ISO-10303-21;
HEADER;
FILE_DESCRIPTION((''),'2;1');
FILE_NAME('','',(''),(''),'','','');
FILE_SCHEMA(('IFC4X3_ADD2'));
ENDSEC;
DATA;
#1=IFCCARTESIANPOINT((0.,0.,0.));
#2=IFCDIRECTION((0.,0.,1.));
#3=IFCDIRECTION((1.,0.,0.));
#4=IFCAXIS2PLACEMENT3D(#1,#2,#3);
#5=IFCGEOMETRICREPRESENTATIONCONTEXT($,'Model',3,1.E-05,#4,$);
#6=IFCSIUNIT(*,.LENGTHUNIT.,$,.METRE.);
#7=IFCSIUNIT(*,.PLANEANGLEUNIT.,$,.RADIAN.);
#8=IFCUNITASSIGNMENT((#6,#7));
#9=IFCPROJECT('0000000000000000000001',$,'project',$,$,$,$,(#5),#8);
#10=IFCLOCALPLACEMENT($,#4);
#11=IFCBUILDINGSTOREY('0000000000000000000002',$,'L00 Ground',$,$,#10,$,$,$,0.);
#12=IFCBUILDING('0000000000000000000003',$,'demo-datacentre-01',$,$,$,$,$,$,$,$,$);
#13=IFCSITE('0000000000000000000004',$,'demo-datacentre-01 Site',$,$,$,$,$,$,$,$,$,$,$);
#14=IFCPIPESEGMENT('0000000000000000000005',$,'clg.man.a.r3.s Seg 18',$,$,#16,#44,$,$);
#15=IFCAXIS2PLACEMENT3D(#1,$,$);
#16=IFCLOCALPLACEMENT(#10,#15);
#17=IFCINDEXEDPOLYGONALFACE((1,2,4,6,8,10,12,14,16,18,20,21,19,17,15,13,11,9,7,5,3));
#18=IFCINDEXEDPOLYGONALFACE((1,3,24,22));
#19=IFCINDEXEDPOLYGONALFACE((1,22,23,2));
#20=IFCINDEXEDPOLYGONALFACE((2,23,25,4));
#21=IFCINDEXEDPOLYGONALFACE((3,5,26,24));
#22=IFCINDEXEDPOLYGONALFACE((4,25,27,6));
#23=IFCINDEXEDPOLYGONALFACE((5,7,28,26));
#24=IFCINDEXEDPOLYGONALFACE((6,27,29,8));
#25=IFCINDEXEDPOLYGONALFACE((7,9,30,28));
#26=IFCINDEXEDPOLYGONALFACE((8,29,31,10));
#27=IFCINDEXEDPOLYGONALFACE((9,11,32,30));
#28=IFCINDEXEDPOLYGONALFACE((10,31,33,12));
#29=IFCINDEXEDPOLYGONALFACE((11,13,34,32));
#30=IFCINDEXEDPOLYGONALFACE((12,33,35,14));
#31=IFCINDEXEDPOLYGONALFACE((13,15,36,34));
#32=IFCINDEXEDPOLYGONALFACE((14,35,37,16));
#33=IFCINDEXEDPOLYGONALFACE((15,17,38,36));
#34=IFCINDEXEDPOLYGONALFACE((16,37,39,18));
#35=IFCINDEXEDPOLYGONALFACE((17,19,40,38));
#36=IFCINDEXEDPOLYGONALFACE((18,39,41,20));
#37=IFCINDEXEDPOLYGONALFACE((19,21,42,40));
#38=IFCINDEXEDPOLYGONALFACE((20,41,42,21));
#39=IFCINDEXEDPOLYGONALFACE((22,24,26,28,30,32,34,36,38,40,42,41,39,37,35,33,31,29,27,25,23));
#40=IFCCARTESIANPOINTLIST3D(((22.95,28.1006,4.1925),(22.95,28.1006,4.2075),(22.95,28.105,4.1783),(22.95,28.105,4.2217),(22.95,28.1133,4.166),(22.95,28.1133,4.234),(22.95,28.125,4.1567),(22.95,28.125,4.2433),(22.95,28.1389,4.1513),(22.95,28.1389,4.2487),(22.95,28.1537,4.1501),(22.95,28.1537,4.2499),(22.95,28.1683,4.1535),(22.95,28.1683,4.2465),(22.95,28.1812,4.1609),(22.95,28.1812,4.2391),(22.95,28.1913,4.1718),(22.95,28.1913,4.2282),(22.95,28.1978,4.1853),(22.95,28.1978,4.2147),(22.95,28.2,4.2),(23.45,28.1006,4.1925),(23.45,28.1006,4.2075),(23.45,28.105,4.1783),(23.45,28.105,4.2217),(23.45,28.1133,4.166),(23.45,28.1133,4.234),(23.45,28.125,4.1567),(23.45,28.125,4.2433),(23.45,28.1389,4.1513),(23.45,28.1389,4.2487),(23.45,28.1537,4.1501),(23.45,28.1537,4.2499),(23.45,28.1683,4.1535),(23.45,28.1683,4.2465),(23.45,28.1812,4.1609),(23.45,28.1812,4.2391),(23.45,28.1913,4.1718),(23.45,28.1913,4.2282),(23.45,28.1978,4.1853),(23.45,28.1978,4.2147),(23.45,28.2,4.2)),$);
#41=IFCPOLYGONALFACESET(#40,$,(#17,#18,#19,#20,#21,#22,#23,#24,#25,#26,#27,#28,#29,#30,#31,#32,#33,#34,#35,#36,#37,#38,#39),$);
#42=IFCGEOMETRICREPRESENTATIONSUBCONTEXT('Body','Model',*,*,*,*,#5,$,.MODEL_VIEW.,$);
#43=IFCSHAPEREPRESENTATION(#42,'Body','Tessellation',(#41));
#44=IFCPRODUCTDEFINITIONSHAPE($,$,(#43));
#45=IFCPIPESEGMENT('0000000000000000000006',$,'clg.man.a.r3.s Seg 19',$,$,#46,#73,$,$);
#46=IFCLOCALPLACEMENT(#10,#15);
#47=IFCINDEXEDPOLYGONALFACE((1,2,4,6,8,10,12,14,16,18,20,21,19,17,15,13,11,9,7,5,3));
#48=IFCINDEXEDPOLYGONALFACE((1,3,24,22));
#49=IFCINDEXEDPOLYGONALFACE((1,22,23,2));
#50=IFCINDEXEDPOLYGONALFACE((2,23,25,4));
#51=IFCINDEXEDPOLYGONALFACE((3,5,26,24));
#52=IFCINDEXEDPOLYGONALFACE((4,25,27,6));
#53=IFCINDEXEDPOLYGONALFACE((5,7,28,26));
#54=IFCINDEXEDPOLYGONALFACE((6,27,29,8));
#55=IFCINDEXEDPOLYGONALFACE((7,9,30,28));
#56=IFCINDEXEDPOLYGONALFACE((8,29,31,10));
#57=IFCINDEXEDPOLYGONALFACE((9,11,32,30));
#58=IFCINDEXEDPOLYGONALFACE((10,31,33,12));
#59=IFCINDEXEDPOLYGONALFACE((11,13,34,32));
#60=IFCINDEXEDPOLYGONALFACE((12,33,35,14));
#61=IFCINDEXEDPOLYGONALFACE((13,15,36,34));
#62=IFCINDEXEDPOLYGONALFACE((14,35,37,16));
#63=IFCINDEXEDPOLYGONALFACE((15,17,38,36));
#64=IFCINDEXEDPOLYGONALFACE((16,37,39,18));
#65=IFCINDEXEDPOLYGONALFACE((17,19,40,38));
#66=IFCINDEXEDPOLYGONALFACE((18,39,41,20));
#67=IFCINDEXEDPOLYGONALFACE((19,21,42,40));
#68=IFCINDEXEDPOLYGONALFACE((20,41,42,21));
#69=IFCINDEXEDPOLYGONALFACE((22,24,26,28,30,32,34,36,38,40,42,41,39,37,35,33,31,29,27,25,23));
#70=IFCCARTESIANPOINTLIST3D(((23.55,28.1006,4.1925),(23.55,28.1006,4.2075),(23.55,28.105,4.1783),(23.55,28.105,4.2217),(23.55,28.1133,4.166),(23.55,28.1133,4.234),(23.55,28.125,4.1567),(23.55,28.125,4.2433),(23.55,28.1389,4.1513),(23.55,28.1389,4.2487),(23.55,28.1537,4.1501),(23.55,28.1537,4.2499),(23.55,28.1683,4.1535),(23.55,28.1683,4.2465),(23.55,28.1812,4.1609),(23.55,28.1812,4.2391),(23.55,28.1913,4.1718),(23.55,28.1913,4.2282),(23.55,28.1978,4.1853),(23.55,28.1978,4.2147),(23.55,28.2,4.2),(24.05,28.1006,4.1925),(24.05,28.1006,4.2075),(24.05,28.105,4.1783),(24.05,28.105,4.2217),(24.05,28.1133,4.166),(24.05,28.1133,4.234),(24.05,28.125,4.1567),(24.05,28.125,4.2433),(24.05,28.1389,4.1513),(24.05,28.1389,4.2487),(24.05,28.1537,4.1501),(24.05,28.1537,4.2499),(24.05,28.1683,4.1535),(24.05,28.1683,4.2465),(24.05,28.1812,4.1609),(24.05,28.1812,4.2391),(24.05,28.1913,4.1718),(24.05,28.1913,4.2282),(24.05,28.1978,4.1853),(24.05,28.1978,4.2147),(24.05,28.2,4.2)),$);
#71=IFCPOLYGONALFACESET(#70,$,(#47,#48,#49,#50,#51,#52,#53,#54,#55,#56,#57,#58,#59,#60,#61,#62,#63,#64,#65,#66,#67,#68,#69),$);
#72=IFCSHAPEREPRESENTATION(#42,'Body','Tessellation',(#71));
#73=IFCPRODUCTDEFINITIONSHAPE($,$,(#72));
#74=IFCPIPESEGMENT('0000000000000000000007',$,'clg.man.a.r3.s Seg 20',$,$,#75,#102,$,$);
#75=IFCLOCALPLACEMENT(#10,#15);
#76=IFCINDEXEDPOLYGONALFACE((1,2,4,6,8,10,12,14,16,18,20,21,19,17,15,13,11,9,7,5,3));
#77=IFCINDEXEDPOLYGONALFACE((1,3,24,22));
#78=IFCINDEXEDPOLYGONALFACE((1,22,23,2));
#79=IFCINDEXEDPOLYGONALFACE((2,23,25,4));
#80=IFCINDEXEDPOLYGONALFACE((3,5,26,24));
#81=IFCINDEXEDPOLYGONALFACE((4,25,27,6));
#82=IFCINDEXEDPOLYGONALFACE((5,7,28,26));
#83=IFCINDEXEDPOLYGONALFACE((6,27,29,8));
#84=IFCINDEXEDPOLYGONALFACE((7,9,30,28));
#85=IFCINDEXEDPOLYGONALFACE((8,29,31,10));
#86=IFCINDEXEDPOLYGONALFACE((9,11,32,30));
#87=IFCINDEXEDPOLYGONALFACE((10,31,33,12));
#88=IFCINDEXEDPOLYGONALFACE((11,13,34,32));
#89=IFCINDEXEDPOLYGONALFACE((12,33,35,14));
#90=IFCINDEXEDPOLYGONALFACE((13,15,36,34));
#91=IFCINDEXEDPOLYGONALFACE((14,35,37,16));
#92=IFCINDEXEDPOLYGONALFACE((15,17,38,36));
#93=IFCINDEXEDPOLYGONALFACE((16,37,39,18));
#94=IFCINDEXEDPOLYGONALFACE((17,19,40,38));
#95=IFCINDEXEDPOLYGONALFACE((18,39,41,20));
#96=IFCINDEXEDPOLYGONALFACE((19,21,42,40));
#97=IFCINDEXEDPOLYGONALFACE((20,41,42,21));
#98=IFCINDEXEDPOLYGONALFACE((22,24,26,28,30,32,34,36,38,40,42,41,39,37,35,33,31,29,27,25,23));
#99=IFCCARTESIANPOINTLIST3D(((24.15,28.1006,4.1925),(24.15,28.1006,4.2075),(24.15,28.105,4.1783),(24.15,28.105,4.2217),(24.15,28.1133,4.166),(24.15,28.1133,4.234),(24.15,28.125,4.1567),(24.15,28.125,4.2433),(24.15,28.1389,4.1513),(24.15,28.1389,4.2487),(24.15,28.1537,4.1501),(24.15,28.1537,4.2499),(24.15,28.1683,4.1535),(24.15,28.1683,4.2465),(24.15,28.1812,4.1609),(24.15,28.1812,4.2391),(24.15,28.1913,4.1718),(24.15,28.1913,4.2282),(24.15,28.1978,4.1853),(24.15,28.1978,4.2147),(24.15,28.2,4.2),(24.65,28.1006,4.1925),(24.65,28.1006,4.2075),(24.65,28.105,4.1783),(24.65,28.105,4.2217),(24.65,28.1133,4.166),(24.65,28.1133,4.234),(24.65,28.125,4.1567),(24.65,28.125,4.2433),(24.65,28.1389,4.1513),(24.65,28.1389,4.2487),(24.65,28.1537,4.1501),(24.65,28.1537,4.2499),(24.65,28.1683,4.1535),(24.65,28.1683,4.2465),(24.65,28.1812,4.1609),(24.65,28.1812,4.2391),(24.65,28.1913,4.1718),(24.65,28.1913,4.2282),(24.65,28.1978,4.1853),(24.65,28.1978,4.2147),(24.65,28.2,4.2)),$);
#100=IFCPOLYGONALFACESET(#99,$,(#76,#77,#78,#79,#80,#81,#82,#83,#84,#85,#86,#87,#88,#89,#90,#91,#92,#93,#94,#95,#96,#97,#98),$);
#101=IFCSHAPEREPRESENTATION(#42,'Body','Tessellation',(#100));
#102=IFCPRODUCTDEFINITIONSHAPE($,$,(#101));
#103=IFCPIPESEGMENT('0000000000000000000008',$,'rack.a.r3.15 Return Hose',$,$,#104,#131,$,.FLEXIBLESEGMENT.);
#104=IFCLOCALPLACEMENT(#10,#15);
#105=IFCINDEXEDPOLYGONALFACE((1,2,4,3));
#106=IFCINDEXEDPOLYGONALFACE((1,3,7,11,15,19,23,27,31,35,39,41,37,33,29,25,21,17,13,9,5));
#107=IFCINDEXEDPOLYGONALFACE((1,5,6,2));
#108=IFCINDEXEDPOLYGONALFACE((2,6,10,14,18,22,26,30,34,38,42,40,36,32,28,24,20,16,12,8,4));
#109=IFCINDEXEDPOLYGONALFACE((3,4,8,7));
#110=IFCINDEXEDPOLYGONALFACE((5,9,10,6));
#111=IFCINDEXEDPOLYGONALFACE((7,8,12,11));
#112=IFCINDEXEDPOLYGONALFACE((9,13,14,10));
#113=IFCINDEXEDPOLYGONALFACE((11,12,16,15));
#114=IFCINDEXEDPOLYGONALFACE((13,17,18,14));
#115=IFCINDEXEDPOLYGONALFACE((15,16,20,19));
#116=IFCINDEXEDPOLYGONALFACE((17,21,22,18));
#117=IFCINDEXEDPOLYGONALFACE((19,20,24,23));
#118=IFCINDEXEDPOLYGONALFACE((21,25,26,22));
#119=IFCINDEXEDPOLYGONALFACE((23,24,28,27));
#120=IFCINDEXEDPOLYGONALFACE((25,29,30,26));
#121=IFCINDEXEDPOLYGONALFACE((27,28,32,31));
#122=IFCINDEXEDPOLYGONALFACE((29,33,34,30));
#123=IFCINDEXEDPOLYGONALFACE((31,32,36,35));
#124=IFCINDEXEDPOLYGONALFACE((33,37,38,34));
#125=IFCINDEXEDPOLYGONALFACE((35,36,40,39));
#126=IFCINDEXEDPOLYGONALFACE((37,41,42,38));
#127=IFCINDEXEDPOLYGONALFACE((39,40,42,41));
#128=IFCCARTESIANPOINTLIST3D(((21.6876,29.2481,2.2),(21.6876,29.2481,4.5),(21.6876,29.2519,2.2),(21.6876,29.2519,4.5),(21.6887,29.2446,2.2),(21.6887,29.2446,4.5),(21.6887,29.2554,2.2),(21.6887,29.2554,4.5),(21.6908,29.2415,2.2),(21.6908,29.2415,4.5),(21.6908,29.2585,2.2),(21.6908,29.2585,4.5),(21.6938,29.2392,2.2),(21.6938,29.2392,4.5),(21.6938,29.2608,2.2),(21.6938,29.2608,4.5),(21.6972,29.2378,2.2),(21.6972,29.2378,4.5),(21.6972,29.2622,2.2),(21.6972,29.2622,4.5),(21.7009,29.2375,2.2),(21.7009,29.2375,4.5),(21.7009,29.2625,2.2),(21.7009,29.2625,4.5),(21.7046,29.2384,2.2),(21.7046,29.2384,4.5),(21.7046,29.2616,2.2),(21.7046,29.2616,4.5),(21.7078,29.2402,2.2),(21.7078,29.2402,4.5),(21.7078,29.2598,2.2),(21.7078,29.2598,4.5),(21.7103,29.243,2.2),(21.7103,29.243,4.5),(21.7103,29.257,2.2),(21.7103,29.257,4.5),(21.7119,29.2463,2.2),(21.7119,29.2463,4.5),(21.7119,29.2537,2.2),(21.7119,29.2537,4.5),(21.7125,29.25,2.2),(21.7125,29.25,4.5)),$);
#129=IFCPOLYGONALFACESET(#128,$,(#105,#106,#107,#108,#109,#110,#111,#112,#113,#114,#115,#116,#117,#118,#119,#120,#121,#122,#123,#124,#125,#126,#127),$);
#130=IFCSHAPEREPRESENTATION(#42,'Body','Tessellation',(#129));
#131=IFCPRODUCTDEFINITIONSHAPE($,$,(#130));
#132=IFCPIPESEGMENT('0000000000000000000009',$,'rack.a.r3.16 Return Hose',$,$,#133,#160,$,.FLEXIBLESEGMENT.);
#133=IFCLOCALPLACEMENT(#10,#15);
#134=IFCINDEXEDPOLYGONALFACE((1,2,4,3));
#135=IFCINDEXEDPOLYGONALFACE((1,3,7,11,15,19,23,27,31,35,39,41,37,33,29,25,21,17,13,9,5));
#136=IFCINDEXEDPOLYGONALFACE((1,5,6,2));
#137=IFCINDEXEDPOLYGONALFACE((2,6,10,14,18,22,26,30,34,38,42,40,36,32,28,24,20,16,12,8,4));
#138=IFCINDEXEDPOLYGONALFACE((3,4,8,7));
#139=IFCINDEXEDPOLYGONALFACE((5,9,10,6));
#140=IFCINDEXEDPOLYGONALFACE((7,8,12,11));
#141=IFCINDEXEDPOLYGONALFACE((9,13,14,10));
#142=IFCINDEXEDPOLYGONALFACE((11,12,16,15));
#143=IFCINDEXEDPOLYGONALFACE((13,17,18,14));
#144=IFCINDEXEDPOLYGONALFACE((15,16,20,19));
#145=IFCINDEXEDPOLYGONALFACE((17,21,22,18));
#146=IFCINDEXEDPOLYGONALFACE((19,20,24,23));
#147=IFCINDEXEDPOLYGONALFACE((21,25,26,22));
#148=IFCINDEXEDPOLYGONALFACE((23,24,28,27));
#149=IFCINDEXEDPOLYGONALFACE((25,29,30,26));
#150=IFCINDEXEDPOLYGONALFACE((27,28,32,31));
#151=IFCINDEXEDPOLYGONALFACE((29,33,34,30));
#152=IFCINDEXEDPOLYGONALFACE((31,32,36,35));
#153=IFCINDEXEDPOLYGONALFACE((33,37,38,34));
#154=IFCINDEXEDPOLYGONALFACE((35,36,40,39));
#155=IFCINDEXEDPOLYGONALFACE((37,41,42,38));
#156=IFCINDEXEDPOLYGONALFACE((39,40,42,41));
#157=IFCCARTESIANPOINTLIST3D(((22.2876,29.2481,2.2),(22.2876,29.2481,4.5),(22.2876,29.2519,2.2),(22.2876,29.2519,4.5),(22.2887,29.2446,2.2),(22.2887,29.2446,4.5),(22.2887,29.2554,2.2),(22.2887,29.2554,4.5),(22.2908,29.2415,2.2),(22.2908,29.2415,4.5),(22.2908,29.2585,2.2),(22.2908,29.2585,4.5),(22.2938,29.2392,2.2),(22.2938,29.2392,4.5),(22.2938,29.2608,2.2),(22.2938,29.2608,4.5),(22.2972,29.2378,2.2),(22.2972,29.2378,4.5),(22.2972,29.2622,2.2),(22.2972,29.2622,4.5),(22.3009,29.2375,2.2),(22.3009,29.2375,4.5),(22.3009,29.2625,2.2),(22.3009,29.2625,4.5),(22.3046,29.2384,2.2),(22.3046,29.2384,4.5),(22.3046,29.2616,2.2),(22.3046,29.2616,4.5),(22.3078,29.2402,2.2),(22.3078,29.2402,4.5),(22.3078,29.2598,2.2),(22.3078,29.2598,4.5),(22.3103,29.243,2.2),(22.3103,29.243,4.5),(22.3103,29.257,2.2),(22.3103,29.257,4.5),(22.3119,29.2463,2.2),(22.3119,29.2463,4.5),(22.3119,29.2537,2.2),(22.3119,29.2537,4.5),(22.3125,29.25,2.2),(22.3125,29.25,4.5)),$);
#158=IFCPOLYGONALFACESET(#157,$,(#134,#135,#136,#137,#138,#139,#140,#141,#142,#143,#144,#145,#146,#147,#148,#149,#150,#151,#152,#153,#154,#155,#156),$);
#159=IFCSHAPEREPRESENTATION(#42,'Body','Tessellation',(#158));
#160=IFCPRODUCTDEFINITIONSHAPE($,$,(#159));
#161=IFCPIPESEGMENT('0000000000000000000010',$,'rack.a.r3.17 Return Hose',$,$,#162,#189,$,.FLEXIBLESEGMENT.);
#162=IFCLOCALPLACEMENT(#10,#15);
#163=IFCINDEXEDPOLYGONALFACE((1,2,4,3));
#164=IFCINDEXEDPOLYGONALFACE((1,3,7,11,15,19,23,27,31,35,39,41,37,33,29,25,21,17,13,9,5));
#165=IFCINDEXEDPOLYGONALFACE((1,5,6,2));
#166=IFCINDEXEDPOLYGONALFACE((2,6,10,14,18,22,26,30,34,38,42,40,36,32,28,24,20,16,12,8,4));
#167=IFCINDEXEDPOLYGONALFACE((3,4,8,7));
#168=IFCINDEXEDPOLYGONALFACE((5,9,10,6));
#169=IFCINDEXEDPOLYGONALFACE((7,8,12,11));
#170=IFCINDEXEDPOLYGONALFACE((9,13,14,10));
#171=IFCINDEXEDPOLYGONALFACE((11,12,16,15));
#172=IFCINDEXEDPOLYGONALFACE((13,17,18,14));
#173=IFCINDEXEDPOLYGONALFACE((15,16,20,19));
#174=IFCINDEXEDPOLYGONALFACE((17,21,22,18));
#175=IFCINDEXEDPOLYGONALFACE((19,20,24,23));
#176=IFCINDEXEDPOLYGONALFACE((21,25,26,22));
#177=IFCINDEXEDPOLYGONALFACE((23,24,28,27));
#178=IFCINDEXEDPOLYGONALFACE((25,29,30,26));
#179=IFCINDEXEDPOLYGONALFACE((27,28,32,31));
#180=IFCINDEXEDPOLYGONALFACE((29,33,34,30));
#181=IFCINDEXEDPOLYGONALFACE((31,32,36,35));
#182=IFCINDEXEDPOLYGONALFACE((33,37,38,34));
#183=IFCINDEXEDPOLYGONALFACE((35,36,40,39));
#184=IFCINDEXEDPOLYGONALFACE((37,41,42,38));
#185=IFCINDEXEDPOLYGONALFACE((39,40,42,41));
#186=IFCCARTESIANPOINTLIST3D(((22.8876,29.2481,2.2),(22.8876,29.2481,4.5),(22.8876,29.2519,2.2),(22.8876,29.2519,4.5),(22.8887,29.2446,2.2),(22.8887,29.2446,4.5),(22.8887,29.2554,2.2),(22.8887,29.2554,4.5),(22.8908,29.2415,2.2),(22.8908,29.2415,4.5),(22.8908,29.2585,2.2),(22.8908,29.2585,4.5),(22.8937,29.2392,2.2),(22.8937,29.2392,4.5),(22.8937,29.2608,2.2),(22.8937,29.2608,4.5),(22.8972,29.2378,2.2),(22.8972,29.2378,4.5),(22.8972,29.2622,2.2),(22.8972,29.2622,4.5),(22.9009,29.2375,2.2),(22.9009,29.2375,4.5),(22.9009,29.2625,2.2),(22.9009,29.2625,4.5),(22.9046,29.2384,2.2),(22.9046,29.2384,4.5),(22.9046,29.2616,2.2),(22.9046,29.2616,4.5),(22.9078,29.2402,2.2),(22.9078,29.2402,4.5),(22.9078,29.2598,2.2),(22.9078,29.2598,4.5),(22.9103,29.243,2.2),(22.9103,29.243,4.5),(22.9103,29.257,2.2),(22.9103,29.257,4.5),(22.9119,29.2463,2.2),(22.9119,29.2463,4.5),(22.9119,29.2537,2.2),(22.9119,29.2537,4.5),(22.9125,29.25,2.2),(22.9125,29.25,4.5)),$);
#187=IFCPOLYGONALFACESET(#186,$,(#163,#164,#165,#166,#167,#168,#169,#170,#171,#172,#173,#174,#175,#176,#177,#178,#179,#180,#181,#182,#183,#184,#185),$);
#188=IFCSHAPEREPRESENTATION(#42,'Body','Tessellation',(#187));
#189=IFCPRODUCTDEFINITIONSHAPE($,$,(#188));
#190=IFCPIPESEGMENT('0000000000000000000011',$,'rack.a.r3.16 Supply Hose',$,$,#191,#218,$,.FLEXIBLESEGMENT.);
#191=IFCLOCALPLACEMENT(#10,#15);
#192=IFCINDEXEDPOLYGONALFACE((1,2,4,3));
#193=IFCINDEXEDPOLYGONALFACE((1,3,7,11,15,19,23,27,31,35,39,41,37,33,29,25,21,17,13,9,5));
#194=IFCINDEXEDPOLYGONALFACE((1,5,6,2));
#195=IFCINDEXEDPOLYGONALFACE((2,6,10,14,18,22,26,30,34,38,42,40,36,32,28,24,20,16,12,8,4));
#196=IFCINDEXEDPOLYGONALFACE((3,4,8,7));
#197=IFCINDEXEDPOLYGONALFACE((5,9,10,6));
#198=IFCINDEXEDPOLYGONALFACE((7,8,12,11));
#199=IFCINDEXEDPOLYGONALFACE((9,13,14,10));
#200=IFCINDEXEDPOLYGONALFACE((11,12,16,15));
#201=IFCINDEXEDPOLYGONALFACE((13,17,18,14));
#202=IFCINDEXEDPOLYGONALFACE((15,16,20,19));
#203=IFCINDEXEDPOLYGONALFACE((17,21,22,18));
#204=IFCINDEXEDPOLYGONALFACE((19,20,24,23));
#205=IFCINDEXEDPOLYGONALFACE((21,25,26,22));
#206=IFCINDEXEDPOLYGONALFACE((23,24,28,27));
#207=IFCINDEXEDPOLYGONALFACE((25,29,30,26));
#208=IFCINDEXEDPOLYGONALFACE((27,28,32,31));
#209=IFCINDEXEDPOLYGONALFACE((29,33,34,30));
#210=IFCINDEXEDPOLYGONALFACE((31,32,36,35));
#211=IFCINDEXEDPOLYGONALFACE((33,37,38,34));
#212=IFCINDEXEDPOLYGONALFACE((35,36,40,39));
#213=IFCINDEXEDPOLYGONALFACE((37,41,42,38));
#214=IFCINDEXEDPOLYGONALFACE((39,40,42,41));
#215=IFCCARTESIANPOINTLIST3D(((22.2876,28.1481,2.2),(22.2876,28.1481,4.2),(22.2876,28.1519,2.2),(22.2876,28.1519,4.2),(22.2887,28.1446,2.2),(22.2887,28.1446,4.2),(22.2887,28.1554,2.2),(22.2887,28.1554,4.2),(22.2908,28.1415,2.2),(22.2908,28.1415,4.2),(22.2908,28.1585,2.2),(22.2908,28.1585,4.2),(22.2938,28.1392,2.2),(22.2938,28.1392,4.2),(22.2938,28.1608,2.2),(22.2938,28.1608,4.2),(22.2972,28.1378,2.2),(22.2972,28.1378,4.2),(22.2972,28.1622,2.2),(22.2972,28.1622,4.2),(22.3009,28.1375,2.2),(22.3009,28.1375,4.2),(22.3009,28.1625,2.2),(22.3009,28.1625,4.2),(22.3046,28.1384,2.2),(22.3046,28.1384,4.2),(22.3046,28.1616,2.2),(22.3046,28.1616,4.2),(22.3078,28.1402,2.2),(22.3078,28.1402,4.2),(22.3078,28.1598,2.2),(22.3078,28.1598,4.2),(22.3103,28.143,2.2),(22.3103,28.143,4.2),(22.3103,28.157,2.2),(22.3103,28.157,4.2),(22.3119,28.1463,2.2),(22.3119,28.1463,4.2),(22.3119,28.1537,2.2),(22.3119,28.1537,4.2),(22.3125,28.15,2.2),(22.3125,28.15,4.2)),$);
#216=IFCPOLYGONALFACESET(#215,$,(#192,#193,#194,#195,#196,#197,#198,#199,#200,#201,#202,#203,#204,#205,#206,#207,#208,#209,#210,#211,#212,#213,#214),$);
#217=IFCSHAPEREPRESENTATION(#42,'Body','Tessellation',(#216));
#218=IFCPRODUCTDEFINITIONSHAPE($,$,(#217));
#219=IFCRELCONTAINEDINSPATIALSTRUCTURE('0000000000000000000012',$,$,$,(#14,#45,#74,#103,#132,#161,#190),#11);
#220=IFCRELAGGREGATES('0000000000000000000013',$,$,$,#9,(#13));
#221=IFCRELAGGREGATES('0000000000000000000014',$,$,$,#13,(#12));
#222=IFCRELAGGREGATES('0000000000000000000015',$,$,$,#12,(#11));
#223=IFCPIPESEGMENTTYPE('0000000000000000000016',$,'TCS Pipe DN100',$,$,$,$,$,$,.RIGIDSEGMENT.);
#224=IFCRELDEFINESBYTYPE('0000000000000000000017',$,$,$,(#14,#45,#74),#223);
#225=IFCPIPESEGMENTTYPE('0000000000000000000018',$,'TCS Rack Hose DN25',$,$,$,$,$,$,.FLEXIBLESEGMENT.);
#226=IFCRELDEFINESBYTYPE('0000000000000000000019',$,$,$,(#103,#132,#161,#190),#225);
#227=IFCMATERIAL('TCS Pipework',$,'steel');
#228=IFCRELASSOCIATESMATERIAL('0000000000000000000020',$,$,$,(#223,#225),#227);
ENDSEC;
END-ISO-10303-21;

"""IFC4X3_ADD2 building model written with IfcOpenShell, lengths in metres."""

from ifc_helpers import new_model, si_unit, frame, origin_with_axes, place, context, subcontext, project, spatial, circle, extrude, material, type_object, element, save


model = new_model("IFC4X3_ADD2")

# Units and contexts
model_context = context("Model", 3, precision=1e-05, world=origin_with_axes())
body_context = subcontext(model_context, "Body", "Model", "MODEL_VIEW")
ifc_project = project(units=[si_unit("LENGTHUNIT", "METRE"), si_unit("PLANEANGLEUNIT", "RADIAN")], contexts=[model_context])

# Site, building, storey
site = spatial("IfcSite", under=ifc_project, Name="demo-datacentre-01 Site")
building = spatial("IfcBuilding", under=site, Name="demo-datacentre-01")
storey_placement = place(None, origin_with_axes())
storey = spatial("IfcBuildingStorey", under=building, at=storey_placement, Name="L00 Ground", Elevation=0.0)

# Shared definitions
ifc_material = material(Name="TCS Pipework", Category="steel")

# Pipe segments
pipe_segment_type_1 = type_object("IfcPipeSegmentType", Name="TCS Pipe DN100", PredefinedType="RIGIDSEGMENT", material=ifc_material)
for number, where, z_axis, x_axis, name in (
    (1, (22.95, 28.15, 4.2), (1.0, 0.0, 0.0), (0.0, 1.0, 0.0), "clg.man.a.r3.s Seg 18"),
    (2, (23.55, 28.15, 4.2), (1.0, 0.0, 0.0), (0.0, 1.0, 0.0), "clg.man.a.r3.s Seg 19"),
    (3, (24.15, 28.15, 4.2), (1.0, 0.0, 0.0), (0.0, 1.0, 0.0), "clg.man.a.r3.s Seg 20"),
):
    element("IfcPipeSegment", number, at=place(storey_placement, frame(where, z_axis=z_axis, x_axis=x_axis)), inside=storey, type_object=pipe_segment_type_1, Name=name, context=body_context, shape_type="SweptSolid", body=[
        extrude(circle(Radius=0.05), origin_with_axes(), (0.0, 0.0, 1.0), 0.5),
    ])
pipe_segment_type_2 = type_object("IfcPipeSegmentType", Name="TCS Rack Hose DN25", PredefinedType="FLEXIBLESEGMENT", material=ifc_material)
for number, where, z_axis, x_axis, name in (
    (4, (21.7, 29.25, 4.5), (0.0, 0.0, -1.0), (1.0, 0.0, 0.0), "rack.a.r3.15 Return Hose"),
    (5, (22.3, 29.25, 4.5), (0.0, 0.0, -1.0), (1.0, 0.0, 0.0), "rack.a.r3.16 Return Hose"),
    (6, (22.9, 29.25, 4.5), (0.0, 0.0, -1.0), (1.0, 0.0, 0.0), "rack.a.r3.17 Return Hose"),
):
    element("IfcPipeSegment", number, at=place(storey_placement, frame(where, z_axis=z_axis, x_axis=x_axis)), inside=storey, type_object=pipe_segment_type_2, Name=name, PredefinedType="FLEXIBLESEGMENT", context=body_context, shape_type="SweptSolid", body=[
        extrude(circle(Radius=0.0125), origin_with_axes(), (0.0, 0.0, 1.0), 2.3),
    ])
for number, where, z_axis, x_axis, name in (
    (7, (22.3, 28.15, 4.2), (0.0, 0.0, -1.0), (1.0, 0.0, 0.0), "rack.a.r3.16 Supply Hose"),
):
    element("IfcPipeSegment", number, at=place(storey_placement, frame(where, z_axis=z_axis, x_axis=x_axis)), inside=storey, type_object=pipe_segment_type_2, Name=name, PredefinedType="FLEXIBLESEGMENT", context=body_context, shape_type="SweptSolid", body=[
        extrude(circle(Radius=0.0125), origin_with_axes(), (0.0, 0.0, 1.0), 2.0),
    ])

save(model, "model.ifc")
